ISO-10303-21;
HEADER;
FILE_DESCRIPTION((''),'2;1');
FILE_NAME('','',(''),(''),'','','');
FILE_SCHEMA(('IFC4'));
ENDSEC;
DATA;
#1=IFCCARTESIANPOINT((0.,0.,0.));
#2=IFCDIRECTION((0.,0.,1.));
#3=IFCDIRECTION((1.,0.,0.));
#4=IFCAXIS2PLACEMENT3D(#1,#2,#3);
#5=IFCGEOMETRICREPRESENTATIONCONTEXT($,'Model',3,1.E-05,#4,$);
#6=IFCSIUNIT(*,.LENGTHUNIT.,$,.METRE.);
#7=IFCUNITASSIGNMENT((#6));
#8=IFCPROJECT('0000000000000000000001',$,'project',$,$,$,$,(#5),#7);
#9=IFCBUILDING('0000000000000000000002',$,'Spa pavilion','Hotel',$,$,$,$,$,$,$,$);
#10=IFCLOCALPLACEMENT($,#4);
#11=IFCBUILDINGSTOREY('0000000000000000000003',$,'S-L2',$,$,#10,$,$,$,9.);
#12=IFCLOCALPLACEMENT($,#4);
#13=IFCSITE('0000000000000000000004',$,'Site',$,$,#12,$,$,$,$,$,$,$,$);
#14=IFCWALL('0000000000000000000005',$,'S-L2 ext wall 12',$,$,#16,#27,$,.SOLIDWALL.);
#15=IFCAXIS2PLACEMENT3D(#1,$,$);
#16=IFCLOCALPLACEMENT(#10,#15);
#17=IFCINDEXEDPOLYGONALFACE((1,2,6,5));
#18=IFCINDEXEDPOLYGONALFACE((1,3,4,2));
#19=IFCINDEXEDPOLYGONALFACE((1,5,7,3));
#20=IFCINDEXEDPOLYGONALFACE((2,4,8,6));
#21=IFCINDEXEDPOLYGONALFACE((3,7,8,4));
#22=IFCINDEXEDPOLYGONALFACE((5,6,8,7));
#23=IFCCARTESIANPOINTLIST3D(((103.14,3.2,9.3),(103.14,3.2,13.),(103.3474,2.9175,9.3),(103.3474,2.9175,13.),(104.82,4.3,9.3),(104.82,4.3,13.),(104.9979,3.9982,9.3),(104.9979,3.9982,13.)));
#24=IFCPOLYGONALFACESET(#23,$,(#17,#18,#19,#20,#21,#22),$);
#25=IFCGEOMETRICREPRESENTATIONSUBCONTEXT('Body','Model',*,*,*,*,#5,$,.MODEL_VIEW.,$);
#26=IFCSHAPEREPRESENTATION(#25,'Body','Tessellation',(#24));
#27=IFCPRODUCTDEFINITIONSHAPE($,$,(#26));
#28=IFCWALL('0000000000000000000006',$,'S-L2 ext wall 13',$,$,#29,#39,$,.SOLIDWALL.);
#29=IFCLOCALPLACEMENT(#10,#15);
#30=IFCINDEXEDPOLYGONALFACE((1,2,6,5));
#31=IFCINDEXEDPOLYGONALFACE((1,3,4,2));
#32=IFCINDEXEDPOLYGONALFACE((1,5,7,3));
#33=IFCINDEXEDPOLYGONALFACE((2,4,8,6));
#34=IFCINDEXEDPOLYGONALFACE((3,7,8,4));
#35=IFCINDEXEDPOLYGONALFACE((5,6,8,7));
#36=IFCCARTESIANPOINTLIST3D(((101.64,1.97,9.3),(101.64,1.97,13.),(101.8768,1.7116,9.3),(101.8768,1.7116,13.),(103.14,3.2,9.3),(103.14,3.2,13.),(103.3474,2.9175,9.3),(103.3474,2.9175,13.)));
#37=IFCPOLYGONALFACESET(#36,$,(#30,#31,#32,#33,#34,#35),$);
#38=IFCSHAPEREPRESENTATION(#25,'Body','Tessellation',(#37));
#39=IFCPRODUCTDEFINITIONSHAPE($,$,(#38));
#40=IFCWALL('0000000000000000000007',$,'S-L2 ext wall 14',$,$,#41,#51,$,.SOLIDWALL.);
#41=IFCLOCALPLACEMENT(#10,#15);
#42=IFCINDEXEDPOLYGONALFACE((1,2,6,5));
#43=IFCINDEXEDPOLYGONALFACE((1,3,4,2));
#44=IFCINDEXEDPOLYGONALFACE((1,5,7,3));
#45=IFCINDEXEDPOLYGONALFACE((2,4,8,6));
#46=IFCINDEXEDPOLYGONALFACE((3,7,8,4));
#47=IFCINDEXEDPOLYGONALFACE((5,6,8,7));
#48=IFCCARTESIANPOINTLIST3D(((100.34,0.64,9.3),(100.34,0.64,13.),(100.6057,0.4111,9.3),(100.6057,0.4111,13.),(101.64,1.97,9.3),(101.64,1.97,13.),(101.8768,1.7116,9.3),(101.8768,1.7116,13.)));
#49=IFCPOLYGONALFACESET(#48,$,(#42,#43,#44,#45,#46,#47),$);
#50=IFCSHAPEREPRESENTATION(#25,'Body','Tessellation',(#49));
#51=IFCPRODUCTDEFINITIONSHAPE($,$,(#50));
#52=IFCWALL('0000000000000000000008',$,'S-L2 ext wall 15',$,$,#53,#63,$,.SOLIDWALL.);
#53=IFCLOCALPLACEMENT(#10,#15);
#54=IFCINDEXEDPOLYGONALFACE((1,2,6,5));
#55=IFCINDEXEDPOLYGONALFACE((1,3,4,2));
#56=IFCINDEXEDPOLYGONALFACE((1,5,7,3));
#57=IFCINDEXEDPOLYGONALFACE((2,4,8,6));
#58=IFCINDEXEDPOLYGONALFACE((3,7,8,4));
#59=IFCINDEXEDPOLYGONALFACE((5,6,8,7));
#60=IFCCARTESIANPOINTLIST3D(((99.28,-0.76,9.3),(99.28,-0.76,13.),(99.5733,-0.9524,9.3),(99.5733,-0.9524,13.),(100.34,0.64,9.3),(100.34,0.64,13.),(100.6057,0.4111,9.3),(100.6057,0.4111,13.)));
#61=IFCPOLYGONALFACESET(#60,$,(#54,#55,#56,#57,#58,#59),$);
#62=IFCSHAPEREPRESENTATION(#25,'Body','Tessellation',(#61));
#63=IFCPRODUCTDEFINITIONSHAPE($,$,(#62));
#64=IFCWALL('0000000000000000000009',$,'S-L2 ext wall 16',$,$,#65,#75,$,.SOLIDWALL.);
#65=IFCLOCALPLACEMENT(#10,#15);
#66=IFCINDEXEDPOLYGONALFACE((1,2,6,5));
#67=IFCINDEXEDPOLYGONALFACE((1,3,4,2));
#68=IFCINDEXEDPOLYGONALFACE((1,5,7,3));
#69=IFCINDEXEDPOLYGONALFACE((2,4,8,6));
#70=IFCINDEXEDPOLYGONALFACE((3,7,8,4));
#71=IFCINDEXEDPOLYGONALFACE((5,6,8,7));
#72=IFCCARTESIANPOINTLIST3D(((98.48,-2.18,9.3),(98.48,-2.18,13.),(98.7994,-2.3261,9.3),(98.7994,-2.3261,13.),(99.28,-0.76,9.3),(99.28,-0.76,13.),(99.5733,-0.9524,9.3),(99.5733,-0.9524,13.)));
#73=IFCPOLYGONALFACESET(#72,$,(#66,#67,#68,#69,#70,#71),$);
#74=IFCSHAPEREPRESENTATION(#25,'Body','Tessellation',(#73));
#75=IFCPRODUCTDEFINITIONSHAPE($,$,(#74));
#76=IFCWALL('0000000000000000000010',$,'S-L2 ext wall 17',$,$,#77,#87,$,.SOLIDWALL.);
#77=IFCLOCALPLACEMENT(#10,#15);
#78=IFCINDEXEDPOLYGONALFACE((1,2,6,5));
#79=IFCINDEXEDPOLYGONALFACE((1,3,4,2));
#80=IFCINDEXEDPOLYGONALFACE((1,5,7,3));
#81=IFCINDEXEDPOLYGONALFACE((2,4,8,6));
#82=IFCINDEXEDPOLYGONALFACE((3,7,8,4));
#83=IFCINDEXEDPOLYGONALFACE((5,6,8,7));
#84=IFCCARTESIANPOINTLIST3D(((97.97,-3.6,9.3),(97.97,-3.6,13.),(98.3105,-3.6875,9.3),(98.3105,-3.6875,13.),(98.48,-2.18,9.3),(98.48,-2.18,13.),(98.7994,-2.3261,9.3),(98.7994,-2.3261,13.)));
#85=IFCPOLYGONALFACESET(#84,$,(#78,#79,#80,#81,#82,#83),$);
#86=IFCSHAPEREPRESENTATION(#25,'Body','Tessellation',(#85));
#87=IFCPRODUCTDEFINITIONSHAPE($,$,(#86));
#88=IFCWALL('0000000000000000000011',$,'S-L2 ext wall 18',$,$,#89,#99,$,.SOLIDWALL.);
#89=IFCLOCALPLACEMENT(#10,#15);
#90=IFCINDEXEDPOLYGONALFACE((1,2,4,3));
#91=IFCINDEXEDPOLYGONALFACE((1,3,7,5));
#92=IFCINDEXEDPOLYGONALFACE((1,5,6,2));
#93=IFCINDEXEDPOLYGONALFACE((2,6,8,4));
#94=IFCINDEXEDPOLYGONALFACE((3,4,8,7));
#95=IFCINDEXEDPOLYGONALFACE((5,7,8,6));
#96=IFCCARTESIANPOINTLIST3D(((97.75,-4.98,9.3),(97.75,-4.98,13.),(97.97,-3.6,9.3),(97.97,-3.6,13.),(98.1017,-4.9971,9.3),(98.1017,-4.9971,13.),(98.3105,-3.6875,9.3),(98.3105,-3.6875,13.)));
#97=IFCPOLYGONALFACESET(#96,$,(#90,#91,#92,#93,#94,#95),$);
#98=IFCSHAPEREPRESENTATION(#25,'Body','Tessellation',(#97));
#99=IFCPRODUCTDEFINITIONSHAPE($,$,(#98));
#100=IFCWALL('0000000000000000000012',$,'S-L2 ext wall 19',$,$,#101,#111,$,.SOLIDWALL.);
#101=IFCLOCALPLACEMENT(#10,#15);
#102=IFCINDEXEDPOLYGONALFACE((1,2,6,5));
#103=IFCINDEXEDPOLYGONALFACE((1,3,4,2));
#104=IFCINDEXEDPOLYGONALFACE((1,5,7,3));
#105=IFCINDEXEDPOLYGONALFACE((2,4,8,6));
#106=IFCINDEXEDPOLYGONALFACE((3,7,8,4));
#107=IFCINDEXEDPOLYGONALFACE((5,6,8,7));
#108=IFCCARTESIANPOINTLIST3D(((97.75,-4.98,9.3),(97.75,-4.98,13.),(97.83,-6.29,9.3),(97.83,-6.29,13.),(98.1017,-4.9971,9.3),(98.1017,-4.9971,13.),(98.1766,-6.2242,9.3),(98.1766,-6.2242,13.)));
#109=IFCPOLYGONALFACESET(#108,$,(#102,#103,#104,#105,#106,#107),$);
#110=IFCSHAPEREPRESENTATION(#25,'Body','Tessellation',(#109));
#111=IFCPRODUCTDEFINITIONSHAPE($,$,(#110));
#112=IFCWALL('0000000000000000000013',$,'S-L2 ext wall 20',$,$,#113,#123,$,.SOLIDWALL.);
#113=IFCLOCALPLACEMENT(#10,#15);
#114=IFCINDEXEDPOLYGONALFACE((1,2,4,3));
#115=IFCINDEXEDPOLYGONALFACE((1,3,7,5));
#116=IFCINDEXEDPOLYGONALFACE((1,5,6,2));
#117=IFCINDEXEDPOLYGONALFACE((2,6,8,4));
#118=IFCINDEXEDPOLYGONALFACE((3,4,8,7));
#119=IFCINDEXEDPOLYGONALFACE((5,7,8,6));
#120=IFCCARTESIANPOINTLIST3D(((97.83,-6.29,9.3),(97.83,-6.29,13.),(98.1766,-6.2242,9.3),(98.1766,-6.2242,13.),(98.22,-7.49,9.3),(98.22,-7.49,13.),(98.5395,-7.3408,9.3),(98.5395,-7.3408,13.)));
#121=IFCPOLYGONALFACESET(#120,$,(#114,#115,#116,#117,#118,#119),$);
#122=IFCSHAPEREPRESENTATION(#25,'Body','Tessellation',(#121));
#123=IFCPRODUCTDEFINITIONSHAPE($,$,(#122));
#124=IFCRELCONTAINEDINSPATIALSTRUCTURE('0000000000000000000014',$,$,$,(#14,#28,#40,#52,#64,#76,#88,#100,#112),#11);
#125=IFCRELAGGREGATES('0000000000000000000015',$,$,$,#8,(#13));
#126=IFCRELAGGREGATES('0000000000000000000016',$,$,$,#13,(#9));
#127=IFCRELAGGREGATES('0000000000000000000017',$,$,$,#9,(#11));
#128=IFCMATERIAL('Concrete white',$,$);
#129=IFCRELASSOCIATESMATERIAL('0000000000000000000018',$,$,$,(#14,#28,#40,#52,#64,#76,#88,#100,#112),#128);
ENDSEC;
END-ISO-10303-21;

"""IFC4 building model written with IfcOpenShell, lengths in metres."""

from ifc_helpers import new_model, si_unit, frame, origin_with_axes, place, context, subcontext, project, spatial, polyline, outline, extrude, material, element, save


model = new_model("IFC4")

# Units and contexts
model_context = context("Model", 3, precision=1e-05, world=origin_with_axes())
body_context = subcontext(model_context, "Body", "Model", "MODEL_VIEW")
ifc_project = project(units=[si_unit("LENGTHUNIT", "METRE")], contexts=[model_context])

# Site, building, storey
site_placement = place(None, origin_with_axes())
site = spatial("IfcSite", under=ifc_project, at=site_placement, Name="Site")
building = spatial("IfcBuilding", under=site, Name="Spa pavilion", Description="Hotel")
storey_placement = place(None, origin_with_axes())
storey = spatial("IfcBuildingStorey", under=building, at=storey_placement, Name="S-L2", Elevation=9.0)

# Walls
ifc_material_1 = material(Name="Concrete white")
wall_1_placement = place(storey_placement, origin_with_axes())
element("IfcWall", 1, at=wall_1_placement, inside=storey, material=ifc_material_1, Name="S-L2 ext wall 12", PredefinedType="SOLIDWALL", context=body_context, shape_type="SweptSolid", body=[
    extrude(outline(polyline([(104.82, 4.3), (103.14, 3.2), (103.3474, 2.9175), (104.9979, 3.9982), (104.82, 4.3)])), frame((0.0, 0.0, 9.3), z_axis=(0.0, 0.0, 1.0), x_axis=(1.0, 0.0, 0.0)), (0.0, 0.0, 1.0), 3.7),
])
wall_2_placement = place(storey_placement, origin_with_axes())
element("IfcWall", 2, at=wall_2_placement, inside=storey, material=ifc_material_1, Name="S-L2 ext wall 13", PredefinedType="SOLIDWALL", context=body_context, shape_type="SweptSolid", body=[
    extrude(outline(polyline([(103.14, 3.2), (101.64, 1.97), (101.8768, 1.7116), (103.3474, 2.9175), (103.14, 3.2)])), frame((0.0, 0.0, 9.3), z_axis=(0.0, 0.0, 1.0), x_axis=(1.0, 0.0, 0.0)), (0.0, 0.0, 1.0), 3.7),
])
wall_3_placement = place(storey_placement, origin_with_axes())
element("IfcWall", 3, at=wall_3_placement, inside=storey, material=ifc_material_1, Name="S-L2 ext wall 14", PredefinedType="SOLIDWALL", context=body_context, shape_type="SweptSolid", body=[
    extrude(outline(polyline([(101.64, 1.97), (100.34, 0.64), (100.6057, 0.4111), (101.8768, 1.7116), (101.64, 1.97)])), frame((0.0, 0.0, 9.3), z_axis=(0.0, 0.0, 1.0), x_axis=(1.0, 0.0, 0.0)), (0.0, 0.0, 1.0), 3.7),
])
wall_4_placement = place(storey_placement, origin_with_axes())
element("IfcWall", 4, at=wall_4_placement, inside=storey, material=ifc_material_1, Name="S-L2 ext wall 15", PredefinedType="SOLIDWALL", context=body_context, shape_type="SweptSolid", body=[
    extrude(outline(polyline([(100.34, 0.64), (99.28, -0.76), (99.5733, -0.9524), (100.6057, 0.4111), (100.34, 0.64)])), frame((0.0, 0.0, 9.3), z_axis=(0.0, 0.0, 1.0), x_axis=(1.0, 0.0, 0.0)), (0.0, 0.0, 1.0), 3.7),
])
wall_5_placement = place(storey_placement, origin_with_axes())
element("IfcWall", 5, at=wall_5_placement, inside=storey, material=ifc_material_1, Name="S-L2 ext wall 16", PredefinedType="SOLIDWALL", context=body_context, shape_type="SweptSolid", body=[
    extrude(outline(polyline([(99.28, -0.76), (98.48, -2.18), (98.7994, -2.3261), (99.5733, -0.9524), (99.28, -0.76)])), frame((0.0, 0.0, 9.3), z_axis=(0.0, 0.0, 1.0), x_axis=(1.0, 0.0, 0.0)), (0.0, 0.0, 1.0), 3.7),
])
wall_6_placement = place(storey_placement, origin_with_axes())
element("IfcWall", 6, at=wall_6_placement, inside=storey, material=ifc_material_1, Name="S-L2 ext wall 17", PredefinedType="SOLIDWALL", context=body_context, shape_type="SweptSolid", body=[
    extrude(outline(polyline([(98.48, -2.18), (97.97, -3.6), (98.3105, -3.6875), (98.7994, -2.3261), (98.48, -2.18)])), frame((0.0, 0.0, 9.3), z_axis=(0.0, 0.0, 1.0), x_axis=(1.0, 0.0, 0.0)), (0.0, 0.0, 1.0), 3.7),
])
wall_7_placement = place(storey_placement, origin_with_axes())
element("IfcWall", 7, at=wall_7_placement, inside=storey, material=ifc_material_1, Name="S-L2 ext wall 18", PredefinedType="SOLIDWALL", context=body_context, shape_type="SweptSolid", body=[
    extrude(outline(polyline([(97.97, -3.6), (97.75, -4.98), (98.1017, -4.9971), (98.3105, -3.6875), (97.97, -3.6)])), frame((0.0, 0.0, 9.3), z_axis=(0.0, 0.0, 1.0), x_axis=(1.0, 0.0, 0.0)), (0.0, 0.0, 1.0), 3.7),
])
wall_8_placement = place(storey_placement, origin_with_axes())
element("IfcWall", 8, at=wall_8_placement, inside=storey, material=ifc_material_1, Name="S-L2 ext wall 19", PredefinedType="SOLIDWALL", context=body_context, shape_type="SweptSolid", body=[
    extrude(outline(polyline([(97.75, -4.98), (97.83, -6.29), (98.1766, -6.2242), (98.1017, -4.9971), (97.75, -4.98)])), frame((0.0, 0.0, 9.3), z_axis=(0.0, 0.0, 1.0), x_axis=(1.0, 0.0, 0.0)), (0.0, 0.0, 1.0), 3.7),
])
wall_9_placement = place(storey_placement, origin_with_axes())
element("IfcWall", 9, at=wall_9_placement, inside=storey, material=ifc_material_1, Name="S-L2 ext wall 20", PredefinedType="SOLIDWALL", context=body_context, shape_type="SweptSolid", body=[
    extrude(outline(polyline([(97.83, -6.29), (98.22, -7.49), (98.5395, -7.3408), (98.1766, -6.2242), (97.83, -6.29)])), frame((0.0, 0.0, 9.3), z_axis=(0.0, 0.0, 1.0), x_axis=(1.0, 0.0, 0.0)), (0.0, 0.0, 1.0), 3.7),
])

save(model, "model.ifc")
